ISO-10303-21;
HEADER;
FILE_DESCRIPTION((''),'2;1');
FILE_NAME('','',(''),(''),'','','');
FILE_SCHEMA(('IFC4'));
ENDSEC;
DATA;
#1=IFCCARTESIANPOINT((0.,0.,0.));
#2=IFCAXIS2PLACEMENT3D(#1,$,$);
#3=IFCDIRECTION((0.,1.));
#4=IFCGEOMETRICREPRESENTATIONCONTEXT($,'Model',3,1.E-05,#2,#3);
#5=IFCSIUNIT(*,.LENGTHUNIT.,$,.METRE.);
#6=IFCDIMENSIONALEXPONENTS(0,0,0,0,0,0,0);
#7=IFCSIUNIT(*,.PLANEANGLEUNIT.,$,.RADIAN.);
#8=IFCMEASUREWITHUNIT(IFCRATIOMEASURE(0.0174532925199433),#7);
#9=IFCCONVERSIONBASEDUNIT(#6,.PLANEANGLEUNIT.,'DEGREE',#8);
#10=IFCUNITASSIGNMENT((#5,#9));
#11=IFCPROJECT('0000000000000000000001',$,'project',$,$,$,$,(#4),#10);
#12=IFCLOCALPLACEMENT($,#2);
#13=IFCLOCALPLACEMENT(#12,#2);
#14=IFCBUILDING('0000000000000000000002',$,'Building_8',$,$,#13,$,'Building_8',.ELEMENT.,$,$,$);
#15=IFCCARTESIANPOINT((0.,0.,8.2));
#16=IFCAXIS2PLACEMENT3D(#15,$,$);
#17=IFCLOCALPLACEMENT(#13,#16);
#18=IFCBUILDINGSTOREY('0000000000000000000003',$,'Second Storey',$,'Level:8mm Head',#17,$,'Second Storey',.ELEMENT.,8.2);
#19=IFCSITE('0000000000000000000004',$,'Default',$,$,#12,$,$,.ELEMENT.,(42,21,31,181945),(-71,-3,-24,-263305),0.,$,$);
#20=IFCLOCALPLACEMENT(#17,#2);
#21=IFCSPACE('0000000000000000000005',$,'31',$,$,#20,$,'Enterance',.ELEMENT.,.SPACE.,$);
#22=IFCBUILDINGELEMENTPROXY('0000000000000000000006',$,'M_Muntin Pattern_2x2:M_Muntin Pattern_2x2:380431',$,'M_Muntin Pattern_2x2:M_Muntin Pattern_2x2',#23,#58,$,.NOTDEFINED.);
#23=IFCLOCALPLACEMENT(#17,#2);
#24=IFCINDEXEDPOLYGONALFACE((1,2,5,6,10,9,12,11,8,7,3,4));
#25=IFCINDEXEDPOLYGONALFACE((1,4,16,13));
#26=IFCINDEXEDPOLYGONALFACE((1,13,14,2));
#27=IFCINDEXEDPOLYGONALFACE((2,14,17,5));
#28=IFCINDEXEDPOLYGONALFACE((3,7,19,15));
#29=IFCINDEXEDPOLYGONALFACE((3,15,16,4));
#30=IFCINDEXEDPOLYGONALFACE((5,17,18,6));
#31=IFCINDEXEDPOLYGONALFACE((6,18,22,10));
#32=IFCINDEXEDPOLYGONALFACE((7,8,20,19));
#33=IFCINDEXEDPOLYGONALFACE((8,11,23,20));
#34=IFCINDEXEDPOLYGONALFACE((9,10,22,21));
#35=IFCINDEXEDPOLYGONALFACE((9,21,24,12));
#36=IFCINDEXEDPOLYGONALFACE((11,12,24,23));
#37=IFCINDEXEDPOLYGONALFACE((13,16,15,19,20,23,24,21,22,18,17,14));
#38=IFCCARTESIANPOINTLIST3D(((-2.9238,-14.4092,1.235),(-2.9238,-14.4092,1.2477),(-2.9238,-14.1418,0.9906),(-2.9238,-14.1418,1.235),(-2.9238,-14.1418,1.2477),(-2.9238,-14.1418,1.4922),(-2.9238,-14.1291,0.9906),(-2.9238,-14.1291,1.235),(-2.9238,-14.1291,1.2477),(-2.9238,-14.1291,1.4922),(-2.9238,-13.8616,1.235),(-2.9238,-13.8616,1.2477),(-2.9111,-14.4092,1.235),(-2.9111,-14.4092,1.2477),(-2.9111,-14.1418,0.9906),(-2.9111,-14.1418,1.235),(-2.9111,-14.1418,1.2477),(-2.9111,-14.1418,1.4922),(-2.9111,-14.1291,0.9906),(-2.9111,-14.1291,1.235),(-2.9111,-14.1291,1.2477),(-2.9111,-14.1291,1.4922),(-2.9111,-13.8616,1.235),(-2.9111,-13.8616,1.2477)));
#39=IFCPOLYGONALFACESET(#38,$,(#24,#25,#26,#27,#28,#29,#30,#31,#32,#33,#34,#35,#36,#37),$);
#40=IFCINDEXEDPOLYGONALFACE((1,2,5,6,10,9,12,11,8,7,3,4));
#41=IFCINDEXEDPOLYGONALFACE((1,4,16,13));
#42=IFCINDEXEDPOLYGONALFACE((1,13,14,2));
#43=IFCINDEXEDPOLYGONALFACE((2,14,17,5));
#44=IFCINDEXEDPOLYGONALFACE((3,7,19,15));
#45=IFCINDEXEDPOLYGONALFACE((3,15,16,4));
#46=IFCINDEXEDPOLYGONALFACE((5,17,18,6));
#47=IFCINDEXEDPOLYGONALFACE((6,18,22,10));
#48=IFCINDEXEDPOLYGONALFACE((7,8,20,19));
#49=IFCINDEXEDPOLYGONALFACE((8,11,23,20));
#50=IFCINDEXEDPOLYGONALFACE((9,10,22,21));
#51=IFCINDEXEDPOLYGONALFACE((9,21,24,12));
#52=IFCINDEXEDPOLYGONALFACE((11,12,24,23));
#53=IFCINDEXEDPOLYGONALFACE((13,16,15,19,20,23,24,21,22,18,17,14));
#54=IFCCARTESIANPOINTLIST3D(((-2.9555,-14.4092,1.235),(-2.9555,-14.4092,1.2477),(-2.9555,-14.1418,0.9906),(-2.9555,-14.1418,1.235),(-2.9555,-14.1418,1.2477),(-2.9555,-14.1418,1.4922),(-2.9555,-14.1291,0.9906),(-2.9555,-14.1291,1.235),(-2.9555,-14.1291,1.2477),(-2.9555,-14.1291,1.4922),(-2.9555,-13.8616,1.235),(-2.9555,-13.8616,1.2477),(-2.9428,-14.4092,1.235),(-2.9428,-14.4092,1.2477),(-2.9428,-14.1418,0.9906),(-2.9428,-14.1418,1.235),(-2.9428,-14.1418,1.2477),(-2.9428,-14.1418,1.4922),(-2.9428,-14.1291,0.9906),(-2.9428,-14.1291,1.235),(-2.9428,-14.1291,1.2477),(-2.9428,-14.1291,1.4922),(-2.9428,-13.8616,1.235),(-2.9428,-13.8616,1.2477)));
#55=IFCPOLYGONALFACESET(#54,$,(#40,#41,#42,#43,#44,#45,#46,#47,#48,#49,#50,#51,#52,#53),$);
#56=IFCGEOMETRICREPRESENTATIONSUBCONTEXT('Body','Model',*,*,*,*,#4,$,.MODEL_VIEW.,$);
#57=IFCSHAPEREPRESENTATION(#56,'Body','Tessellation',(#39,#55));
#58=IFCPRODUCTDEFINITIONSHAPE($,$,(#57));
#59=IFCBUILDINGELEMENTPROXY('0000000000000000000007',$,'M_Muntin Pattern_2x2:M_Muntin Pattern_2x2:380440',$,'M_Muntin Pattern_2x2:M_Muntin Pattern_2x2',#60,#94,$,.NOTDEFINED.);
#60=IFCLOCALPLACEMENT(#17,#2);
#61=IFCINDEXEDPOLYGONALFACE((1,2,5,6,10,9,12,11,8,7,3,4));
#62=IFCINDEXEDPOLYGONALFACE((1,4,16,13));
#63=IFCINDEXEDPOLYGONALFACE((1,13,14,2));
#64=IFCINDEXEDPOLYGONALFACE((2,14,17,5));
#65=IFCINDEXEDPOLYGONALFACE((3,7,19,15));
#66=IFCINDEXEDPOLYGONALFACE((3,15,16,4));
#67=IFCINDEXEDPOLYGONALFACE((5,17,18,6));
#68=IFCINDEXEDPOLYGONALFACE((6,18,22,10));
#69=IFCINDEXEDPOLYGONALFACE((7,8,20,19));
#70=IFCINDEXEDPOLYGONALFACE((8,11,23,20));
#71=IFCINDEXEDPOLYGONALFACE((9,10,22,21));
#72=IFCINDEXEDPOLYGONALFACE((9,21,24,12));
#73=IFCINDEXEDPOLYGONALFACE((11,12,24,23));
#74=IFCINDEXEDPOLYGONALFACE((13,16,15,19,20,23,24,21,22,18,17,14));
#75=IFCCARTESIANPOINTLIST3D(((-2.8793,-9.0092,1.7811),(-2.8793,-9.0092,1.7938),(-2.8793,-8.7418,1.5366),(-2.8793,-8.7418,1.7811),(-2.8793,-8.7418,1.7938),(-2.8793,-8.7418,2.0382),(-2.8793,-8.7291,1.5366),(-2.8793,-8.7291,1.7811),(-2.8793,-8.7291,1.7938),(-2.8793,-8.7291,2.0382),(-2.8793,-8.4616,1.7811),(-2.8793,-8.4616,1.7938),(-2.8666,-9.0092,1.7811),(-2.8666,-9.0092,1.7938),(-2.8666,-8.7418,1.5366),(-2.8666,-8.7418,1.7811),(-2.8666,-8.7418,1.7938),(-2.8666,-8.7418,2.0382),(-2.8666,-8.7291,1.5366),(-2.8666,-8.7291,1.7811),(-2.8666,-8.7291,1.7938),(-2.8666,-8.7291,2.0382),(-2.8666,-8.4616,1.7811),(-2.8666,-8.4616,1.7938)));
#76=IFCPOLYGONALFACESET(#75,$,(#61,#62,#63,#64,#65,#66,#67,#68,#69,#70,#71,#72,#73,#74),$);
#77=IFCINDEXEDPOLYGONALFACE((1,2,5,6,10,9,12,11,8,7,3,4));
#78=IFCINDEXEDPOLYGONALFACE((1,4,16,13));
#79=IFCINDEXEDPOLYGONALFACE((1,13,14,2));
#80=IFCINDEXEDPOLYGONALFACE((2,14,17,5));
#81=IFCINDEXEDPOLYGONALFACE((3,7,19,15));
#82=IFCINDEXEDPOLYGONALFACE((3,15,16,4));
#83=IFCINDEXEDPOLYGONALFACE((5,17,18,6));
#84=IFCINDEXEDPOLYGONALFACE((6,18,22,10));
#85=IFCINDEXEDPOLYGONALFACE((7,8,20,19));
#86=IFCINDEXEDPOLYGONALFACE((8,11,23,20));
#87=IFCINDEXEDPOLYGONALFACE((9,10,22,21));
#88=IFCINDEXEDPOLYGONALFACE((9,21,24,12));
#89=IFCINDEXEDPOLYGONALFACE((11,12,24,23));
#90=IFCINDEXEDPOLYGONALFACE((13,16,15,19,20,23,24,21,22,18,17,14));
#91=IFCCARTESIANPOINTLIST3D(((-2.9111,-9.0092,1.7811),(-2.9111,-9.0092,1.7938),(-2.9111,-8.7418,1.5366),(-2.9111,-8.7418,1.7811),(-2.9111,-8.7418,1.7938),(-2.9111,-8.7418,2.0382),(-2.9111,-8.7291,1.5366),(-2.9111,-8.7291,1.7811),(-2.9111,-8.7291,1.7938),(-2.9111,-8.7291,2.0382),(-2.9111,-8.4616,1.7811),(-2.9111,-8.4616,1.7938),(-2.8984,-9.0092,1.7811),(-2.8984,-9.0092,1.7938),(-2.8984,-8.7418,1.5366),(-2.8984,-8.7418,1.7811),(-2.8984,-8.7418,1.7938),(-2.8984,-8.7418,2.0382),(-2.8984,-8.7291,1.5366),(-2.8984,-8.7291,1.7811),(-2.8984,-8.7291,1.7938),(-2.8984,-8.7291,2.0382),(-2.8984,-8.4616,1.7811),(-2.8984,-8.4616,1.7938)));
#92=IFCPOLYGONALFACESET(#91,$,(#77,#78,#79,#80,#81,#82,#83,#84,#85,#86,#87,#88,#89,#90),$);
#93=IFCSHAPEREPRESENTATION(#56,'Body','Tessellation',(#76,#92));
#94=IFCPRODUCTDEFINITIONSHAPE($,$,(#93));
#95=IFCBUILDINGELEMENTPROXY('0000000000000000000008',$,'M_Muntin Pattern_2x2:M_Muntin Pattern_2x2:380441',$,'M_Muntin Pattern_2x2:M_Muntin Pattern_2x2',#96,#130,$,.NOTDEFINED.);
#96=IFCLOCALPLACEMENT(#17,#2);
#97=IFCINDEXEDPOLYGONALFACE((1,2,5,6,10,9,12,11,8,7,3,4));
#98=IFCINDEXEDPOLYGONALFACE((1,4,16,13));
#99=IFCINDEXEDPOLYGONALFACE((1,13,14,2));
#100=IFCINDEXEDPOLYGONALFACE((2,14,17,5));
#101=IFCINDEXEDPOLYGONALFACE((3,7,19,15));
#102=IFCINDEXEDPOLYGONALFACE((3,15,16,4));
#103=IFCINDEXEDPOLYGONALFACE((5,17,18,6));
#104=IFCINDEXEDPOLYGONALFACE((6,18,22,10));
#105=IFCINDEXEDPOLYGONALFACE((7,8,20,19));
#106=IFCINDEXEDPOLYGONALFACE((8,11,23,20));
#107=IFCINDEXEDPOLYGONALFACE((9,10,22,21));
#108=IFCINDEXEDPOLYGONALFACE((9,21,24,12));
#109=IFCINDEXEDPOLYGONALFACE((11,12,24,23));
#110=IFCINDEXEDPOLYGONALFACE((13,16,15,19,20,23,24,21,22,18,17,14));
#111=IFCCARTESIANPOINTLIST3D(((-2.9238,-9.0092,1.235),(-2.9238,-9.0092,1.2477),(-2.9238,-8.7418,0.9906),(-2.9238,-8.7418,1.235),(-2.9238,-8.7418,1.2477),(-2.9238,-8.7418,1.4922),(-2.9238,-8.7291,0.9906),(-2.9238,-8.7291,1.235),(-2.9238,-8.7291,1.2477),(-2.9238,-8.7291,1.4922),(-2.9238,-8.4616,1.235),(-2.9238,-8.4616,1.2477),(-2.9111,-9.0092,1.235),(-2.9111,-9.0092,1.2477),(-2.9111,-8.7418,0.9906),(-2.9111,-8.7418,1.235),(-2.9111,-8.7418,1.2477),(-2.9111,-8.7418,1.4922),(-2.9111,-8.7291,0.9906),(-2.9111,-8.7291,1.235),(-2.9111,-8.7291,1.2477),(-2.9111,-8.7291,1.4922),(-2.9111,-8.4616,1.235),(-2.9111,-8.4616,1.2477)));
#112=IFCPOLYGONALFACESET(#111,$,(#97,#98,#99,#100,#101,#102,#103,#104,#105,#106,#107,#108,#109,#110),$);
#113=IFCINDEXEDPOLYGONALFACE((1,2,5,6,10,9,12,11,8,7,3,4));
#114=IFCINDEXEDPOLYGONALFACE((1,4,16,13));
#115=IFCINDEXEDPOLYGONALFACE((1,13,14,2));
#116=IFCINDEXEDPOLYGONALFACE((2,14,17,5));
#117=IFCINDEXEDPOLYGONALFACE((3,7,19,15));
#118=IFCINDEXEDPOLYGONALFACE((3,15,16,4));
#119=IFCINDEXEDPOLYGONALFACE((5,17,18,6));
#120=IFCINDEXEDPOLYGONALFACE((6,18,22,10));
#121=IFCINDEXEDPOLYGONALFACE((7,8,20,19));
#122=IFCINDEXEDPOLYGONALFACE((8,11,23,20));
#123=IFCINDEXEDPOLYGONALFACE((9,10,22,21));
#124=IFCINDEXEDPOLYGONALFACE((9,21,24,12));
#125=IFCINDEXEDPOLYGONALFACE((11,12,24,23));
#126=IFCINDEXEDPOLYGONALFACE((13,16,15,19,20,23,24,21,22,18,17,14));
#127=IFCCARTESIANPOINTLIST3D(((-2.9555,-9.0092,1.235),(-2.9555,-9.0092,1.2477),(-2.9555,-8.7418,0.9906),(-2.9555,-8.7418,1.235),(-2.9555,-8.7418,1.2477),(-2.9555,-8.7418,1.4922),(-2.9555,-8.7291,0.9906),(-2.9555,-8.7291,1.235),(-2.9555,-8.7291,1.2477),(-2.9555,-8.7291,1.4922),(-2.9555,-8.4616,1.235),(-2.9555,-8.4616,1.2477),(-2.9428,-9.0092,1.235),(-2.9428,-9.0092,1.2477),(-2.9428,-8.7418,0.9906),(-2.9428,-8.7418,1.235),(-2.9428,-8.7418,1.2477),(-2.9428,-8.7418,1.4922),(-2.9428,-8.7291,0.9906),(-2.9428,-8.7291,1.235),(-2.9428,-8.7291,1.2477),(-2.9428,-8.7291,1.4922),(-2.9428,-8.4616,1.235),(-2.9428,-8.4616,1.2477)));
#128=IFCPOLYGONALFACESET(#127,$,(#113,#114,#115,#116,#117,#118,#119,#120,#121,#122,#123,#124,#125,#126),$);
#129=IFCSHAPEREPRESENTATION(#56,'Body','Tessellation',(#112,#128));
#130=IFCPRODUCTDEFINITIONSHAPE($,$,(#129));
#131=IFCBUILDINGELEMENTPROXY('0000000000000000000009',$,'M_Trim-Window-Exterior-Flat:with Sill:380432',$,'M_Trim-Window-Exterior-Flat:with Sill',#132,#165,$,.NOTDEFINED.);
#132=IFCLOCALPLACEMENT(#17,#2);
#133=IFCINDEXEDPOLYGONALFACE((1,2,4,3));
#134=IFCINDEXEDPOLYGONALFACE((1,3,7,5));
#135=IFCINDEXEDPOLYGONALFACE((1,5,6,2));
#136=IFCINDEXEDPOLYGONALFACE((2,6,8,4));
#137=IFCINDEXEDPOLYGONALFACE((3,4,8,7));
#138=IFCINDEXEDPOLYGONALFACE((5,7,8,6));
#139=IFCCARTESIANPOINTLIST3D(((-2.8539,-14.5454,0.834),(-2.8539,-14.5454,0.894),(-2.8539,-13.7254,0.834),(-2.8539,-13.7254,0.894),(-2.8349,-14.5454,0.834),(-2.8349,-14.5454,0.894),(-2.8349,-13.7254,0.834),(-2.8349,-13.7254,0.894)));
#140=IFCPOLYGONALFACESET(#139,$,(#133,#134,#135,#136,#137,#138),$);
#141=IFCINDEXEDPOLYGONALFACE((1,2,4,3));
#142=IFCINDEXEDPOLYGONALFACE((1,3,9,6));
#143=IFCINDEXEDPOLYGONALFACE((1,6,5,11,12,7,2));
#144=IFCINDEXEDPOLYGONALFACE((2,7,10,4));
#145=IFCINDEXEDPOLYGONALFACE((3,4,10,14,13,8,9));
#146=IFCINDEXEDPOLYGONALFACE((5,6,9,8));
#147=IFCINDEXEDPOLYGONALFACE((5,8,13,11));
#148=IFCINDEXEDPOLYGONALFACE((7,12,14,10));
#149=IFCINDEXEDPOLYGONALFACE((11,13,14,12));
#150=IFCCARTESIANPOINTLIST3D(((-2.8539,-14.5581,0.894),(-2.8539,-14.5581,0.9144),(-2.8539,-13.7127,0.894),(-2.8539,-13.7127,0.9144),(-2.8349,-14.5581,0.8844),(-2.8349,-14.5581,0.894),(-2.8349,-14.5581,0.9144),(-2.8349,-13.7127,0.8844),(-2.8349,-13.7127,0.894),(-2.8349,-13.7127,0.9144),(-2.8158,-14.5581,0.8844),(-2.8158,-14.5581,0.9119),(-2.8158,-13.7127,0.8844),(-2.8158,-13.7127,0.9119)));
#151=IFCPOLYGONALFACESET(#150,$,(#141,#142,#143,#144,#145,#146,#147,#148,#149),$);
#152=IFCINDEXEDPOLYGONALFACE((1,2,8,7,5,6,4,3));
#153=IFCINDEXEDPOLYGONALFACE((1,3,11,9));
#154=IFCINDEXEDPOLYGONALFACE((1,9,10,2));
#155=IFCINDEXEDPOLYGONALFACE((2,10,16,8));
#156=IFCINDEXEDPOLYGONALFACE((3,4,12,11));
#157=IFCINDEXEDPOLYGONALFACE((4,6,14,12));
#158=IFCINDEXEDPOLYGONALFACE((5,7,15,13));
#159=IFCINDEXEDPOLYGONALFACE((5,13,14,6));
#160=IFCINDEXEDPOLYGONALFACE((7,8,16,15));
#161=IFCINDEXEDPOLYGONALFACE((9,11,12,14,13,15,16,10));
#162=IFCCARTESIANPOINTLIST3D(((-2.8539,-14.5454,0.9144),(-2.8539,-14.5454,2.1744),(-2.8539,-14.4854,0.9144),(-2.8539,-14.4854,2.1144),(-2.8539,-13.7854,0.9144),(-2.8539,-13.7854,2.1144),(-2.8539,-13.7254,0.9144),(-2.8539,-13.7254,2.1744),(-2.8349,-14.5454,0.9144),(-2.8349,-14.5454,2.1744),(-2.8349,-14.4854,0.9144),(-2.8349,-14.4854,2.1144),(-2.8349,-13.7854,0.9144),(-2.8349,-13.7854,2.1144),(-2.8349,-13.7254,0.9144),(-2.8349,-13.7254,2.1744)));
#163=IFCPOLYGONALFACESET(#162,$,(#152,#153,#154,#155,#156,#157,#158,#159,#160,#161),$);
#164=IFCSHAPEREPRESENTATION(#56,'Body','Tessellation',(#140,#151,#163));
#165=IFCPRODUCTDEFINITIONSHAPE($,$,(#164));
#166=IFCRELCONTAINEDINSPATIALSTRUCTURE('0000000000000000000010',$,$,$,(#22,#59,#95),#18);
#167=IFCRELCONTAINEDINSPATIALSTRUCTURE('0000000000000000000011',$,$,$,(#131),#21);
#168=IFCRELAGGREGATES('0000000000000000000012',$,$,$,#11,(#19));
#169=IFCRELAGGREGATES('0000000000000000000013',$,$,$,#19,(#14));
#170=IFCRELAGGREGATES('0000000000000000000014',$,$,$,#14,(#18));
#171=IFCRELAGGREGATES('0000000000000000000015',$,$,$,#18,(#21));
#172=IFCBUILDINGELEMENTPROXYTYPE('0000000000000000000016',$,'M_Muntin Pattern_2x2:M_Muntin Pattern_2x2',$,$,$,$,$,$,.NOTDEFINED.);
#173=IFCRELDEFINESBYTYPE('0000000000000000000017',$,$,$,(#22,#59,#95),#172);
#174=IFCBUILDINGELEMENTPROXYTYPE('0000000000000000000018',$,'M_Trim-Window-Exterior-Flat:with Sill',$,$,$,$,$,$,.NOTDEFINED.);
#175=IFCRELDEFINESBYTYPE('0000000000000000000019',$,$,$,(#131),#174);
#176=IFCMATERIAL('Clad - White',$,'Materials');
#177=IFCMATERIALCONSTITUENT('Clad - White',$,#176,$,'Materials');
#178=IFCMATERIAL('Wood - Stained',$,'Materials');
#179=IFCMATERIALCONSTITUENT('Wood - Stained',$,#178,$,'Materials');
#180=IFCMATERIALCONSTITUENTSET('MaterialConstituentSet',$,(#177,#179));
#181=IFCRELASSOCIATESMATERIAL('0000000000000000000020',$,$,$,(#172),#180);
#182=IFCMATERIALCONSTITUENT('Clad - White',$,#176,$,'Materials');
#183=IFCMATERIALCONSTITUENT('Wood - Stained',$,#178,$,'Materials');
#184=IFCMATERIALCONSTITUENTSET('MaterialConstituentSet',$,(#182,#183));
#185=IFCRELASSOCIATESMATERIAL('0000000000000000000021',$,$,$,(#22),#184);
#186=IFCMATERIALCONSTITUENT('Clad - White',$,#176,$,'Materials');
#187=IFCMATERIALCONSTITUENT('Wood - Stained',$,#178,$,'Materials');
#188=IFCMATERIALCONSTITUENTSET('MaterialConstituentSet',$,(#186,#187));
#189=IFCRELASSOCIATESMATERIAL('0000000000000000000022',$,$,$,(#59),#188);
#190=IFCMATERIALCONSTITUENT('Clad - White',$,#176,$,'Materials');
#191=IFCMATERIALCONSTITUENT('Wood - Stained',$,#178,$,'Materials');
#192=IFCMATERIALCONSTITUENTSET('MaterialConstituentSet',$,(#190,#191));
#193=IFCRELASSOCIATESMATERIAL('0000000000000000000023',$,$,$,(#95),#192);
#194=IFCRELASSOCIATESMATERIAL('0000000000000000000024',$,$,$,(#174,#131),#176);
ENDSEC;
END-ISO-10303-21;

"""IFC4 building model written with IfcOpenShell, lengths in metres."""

from ifc_helpers import new_model, entity, si_unit, converted_unit, direction, frame, origin, place, context, subcontext, project, spatial, indexed_curve, outline, extrude, source, transform, mapped, material, constituent, constituent_set, type_object, type_shapes, element, save


model = new_model("IFC4")

# Units and contexts
model_context = context("Model", 3, precision=1e-05, world=origin(), true_north=direction((0.0, 1.0)))
body_context = subcontext(model_context, "Body", "Model", "MODEL_VIEW")
ifc_project = project(units=[si_unit("LENGTHUNIT", "METRE"), converted_unit("PLANEANGLEUNIT", "DEGREE", entity("IfcRatioMeasure", 0.0174532925199433), si_unit("PLANEANGLEUNIT", "RADIAN"), dimensions=[0, 0, 0, 0, 0, 0, 0])], contexts=[model_context])

# Site, building, storey
site_placement = place(None, origin())
site = spatial("IfcSite", under=ifc_project, at=site_placement, Name="Default", CompositionType="ELEMENT", RefLatitude=(42, 21, 31, 181945), RefLongitude=(-71, -3, -24, -263305), RefElevation=0.0)
building_placement = place(site_placement, origin())
building = spatial("IfcBuilding", under=site, at=building_placement, Name="Building_8", LongName="Building_8", CompositionType="ELEMENT")
storey_placement = place(building_placement, frame((0.0, 0.0, 8.2)))
storey = spatial("IfcBuildingStorey", under=building, at=storey_placement, Name="Second Storey", ObjectType="Level:8mm Head", LongName="Second Storey", CompositionType="ELEMENT", Elevation=8.2)

# Building element proxies
ifc_material_1 = material(Name="Clad - White", Category="Materials")
ifc_material_2 = material(Name="Wood - Stained", Category="Materials")
ifc_constituent_1 = constituent(ifc_material_1, Name="Clad - White", Category="Materials")
ifc_constituent_2 = constituent(ifc_material_2, Name="Wood - Stained", Category="Materials")
ifc_constituent_set_1 = constituent_set(constituents=[ifc_constituent_1, ifc_constituent_2], Name="MaterialConstituentSet")
building_element_proxy_type_1 = type_object("IfcBuildingElementProxyType", Name="M_Muntin Pattern_2x2:M_Muntin Pattern_2x2", PredefinedType="NOTDEFINED", material=ifc_constituent_set_1)
shared_shape_1 = source(origin(), body_context, "Body", "SweptSolid", [
    extrude(outline(indexed_curve([(0.0064, -0.0064), (0.2508, -0.0064), (0.2508, 0.0063), (0.0064, 0.0063), (0.0064, 0.2738), (-0.0063, 0.2738), (-0.0063, 0.0063), (-0.2508, 0.0063), (-0.2508, -0.0064), (-0.0063, -0.0064), (-0.0063, -0.2738), (0.0064, -0.2738), (0.0064, -0.0064)], self_intersect=False)), frame((0.0, 0.0095, 0.2508), z_axis=(0.0, 1.0, 0.0), x_axis=(0.0, 0.0, 1.0)), (0.0, 0.0, 1.0), 0.0127),
    extrude(outline(indexed_curve([(0.0064, -0.0064), (0.2508, -0.0064), (0.2508, 0.0063), (0.0064, 0.0063), (0.0064, 0.2738), (-0.0063, 0.2738), (-0.0063, 0.0063), (-0.2508, 0.0063), (-0.2508, -0.0064), (-0.0063, -0.0064), (-0.0063, -0.2738), (0.0064, -0.2738), (0.0064, -0.0064)], self_intersect=False)), frame((0.0, -0.0222, 0.2508), z_axis=(0.0, 1.0, 0.0), x_axis=(0.0, 0.0, 1.0)), (0.0, 0.0, 1.0), 0.0127),
])
type_shapes(building_element_proxy_type_1, [shared_shape_1])
ifc_constituent_3 = constituent(ifc_material_1, Name="Clad - White", Category="Materials")
ifc_constituent_4 = constituent(ifc_material_2, Name="Wood - Stained", Category="Materials")
ifc_constituent_set_2 = constituent_set(constituents=[ifc_constituent_3, ifc_constituent_4], Name="MaterialConstituentSet")
proxy_1_placement = place(storey_placement, frame((-2.9333, -14.1354, 0.9906), z_axis=(0.0, 0.0, 1.0), x_axis=(0.0, -1.0, 0.0)))
element("IfcBuildingElementProxy", 1, at=proxy_1_placement, inside=storey, type_object=building_element_proxy_type_1, material=ifc_constituent_set_2, Name="M_Muntin Pattern_2x2:M_Muntin Pattern_2x2:380431", ObjectType="M_Muntin Pattern_2x2:M_Muntin Pattern_2x2", PredefinedType="NOTDEFINED", context=body_context, shape_type="MappedRepresentation", body=[
    mapped(shared_shape_1, transform((0.0, 0.0, 0.0), scale=1.0)),
])
ifc_constituent_5 = constituent(ifc_material_1, Name="Clad - White", Category="Materials")
ifc_constituent_6 = constituent(ifc_material_2, Name="Wood - Stained", Category="Materials")
ifc_constituent_set_3 = constituent_set(constituents=[ifc_constituent_5, ifc_constituent_6], Name="MaterialConstituentSet")
proxy_2_placement = place(storey_placement, frame((-2.8888, -8.7354, 1.5366), z_axis=(0.0, 0.0, 1.0), x_axis=(0.0, -1.0, 0.0)))
element("IfcBuildingElementProxy", 2, at=proxy_2_placement, inside=storey, type_object=building_element_proxy_type_1, material=ifc_constituent_set_3, Name="M_Muntin Pattern_2x2:M_Muntin Pattern_2x2:380440", ObjectType="M_Muntin Pattern_2x2:M_Muntin Pattern_2x2", PredefinedType="NOTDEFINED", context=body_context, shape_type="MappedRepresentation", body=[
    mapped(shared_shape_1, transform((0.0, 0.0, 0.0), scale=1.0)),
])
ifc_constituent_7 = constituent(ifc_material_1, Name="Clad - White", Category="Materials")
ifc_constituent_8 = constituent(ifc_material_2, Name="Wood - Stained", Category="Materials")
ifc_constituent_set_4 = constituent_set(constituents=[ifc_constituent_7, ifc_constituent_8], Name="MaterialConstituentSet")
proxy_3_placement = place(storey_placement, frame((-2.9333, -8.7354, 0.9906), z_axis=(0.0, 0.0, 1.0), x_axis=(0.0, -1.0, 0.0)))
element("IfcBuildingElementProxy", 3, at=proxy_3_placement, inside=storey, type_object=building_element_proxy_type_1, material=ifc_constituent_set_4, Name="M_Muntin Pattern_2x2:M_Muntin Pattern_2x2:380441", ObjectType="M_Muntin Pattern_2x2:M_Muntin Pattern_2x2", PredefinedType="NOTDEFINED", context=body_context, shape_type="MappedRepresentation", body=[
    mapped(shared_shape_1, transform((0.0, 0.0, 0.0), scale=1.0)),
])

# Shared definitions
space_1_placement = place(storey_placement, origin())
space_1 = spatial("IfcSpace", under=storey, at=space_1_placement, Name="31", LongName="Enterance", CompositionType="ELEMENT", PredefinedType="SPACE")

# Building element proxy
building_element_proxy_type_2 = type_object("IfcBuildingElementProxyType", Name="M_Trim-Window-Exterior-Flat:with Sill", PredefinedType="NOTDEFINED", material=ifc_material_1)
shared_shape_2 = source(origin(), body_context, "Body", "SweptSolid", [
    extrude(outline(indexed_curve([(-0.41, -0.03), (0.41, -0.03), (0.41, 0.03), (-0.41, 0.03), (-0.41, -0.03)], self_intersect=False)), frame((0.0, -1.2504, 0.0), z_axis=(0.0, 0.0, 1.0), x_axis=(-1.0, 0.0, 0.0)), (0.0, 0.0, 1.0), 0.0191),
    extrude(outline(indexed_curve([(-0.019, -0.0152), (0.0, -0.0152), (0.0, -0.0057), (0.019, -0.0057), (0.019, 0.0148), (0.0, 0.0148), (-0.019, 0.0123), (-0.019, -0.0152)], self_intersect=False)), frame((-0.4227, -1.2148, 0.019), z_axis=(1.0, 0.0, 0.0), x_axis=(0.0, 0.0, -1.0)), (0.0, 0.0, 1.0), 0.8454),
    extrude(outline(indexed_curve([(-0.645, -0.41), (0.615, -0.41), (0.615, -0.35), (-0.585, -0.35), (-0.585, 0.35), (0.615, 0.35), (0.615, 0.41), (-0.645, 0.41), (-0.645, -0.41)], self_intersect=False)), frame((0.0, -0.585, 0.0), z_axis=(0.0, 0.0, 1.0), x_axis=(0.0, -1.0, 0.0)), (0.0, 0.0, 1.0), 0.0191),
])
type_shapes(building_element_proxy_type_2, [shared_shape_2])
for number, where, z_axis, x_axis, name in (
    (4, (-2.8539, -14.1354, 2.1144), (1.0, 0.0, 0.0), (0.0, 1.0, 0.0), "M_Trim-Window-Exterior-Flat:with Sill:380432"),
):
    element("IfcBuildingElementProxy", number, at=place(space_1_placement, frame(where, z_axis=z_axis, x_axis=x_axis)), inside=space_1, type_object=building_element_proxy_type_2, material=ifc_material_1, Name=name, ObjectType="M_Trim-Window-Exterior-Flat:with Sill", PredefinedType="NOTDEFINED", context=body_context, shape_type="MappedRepresentation", body=[
        mapped(shared_shape_2, transform((0.0, 0.0, 0.0), scale=1.0)),
    ])

save(model, "model.ifc")
